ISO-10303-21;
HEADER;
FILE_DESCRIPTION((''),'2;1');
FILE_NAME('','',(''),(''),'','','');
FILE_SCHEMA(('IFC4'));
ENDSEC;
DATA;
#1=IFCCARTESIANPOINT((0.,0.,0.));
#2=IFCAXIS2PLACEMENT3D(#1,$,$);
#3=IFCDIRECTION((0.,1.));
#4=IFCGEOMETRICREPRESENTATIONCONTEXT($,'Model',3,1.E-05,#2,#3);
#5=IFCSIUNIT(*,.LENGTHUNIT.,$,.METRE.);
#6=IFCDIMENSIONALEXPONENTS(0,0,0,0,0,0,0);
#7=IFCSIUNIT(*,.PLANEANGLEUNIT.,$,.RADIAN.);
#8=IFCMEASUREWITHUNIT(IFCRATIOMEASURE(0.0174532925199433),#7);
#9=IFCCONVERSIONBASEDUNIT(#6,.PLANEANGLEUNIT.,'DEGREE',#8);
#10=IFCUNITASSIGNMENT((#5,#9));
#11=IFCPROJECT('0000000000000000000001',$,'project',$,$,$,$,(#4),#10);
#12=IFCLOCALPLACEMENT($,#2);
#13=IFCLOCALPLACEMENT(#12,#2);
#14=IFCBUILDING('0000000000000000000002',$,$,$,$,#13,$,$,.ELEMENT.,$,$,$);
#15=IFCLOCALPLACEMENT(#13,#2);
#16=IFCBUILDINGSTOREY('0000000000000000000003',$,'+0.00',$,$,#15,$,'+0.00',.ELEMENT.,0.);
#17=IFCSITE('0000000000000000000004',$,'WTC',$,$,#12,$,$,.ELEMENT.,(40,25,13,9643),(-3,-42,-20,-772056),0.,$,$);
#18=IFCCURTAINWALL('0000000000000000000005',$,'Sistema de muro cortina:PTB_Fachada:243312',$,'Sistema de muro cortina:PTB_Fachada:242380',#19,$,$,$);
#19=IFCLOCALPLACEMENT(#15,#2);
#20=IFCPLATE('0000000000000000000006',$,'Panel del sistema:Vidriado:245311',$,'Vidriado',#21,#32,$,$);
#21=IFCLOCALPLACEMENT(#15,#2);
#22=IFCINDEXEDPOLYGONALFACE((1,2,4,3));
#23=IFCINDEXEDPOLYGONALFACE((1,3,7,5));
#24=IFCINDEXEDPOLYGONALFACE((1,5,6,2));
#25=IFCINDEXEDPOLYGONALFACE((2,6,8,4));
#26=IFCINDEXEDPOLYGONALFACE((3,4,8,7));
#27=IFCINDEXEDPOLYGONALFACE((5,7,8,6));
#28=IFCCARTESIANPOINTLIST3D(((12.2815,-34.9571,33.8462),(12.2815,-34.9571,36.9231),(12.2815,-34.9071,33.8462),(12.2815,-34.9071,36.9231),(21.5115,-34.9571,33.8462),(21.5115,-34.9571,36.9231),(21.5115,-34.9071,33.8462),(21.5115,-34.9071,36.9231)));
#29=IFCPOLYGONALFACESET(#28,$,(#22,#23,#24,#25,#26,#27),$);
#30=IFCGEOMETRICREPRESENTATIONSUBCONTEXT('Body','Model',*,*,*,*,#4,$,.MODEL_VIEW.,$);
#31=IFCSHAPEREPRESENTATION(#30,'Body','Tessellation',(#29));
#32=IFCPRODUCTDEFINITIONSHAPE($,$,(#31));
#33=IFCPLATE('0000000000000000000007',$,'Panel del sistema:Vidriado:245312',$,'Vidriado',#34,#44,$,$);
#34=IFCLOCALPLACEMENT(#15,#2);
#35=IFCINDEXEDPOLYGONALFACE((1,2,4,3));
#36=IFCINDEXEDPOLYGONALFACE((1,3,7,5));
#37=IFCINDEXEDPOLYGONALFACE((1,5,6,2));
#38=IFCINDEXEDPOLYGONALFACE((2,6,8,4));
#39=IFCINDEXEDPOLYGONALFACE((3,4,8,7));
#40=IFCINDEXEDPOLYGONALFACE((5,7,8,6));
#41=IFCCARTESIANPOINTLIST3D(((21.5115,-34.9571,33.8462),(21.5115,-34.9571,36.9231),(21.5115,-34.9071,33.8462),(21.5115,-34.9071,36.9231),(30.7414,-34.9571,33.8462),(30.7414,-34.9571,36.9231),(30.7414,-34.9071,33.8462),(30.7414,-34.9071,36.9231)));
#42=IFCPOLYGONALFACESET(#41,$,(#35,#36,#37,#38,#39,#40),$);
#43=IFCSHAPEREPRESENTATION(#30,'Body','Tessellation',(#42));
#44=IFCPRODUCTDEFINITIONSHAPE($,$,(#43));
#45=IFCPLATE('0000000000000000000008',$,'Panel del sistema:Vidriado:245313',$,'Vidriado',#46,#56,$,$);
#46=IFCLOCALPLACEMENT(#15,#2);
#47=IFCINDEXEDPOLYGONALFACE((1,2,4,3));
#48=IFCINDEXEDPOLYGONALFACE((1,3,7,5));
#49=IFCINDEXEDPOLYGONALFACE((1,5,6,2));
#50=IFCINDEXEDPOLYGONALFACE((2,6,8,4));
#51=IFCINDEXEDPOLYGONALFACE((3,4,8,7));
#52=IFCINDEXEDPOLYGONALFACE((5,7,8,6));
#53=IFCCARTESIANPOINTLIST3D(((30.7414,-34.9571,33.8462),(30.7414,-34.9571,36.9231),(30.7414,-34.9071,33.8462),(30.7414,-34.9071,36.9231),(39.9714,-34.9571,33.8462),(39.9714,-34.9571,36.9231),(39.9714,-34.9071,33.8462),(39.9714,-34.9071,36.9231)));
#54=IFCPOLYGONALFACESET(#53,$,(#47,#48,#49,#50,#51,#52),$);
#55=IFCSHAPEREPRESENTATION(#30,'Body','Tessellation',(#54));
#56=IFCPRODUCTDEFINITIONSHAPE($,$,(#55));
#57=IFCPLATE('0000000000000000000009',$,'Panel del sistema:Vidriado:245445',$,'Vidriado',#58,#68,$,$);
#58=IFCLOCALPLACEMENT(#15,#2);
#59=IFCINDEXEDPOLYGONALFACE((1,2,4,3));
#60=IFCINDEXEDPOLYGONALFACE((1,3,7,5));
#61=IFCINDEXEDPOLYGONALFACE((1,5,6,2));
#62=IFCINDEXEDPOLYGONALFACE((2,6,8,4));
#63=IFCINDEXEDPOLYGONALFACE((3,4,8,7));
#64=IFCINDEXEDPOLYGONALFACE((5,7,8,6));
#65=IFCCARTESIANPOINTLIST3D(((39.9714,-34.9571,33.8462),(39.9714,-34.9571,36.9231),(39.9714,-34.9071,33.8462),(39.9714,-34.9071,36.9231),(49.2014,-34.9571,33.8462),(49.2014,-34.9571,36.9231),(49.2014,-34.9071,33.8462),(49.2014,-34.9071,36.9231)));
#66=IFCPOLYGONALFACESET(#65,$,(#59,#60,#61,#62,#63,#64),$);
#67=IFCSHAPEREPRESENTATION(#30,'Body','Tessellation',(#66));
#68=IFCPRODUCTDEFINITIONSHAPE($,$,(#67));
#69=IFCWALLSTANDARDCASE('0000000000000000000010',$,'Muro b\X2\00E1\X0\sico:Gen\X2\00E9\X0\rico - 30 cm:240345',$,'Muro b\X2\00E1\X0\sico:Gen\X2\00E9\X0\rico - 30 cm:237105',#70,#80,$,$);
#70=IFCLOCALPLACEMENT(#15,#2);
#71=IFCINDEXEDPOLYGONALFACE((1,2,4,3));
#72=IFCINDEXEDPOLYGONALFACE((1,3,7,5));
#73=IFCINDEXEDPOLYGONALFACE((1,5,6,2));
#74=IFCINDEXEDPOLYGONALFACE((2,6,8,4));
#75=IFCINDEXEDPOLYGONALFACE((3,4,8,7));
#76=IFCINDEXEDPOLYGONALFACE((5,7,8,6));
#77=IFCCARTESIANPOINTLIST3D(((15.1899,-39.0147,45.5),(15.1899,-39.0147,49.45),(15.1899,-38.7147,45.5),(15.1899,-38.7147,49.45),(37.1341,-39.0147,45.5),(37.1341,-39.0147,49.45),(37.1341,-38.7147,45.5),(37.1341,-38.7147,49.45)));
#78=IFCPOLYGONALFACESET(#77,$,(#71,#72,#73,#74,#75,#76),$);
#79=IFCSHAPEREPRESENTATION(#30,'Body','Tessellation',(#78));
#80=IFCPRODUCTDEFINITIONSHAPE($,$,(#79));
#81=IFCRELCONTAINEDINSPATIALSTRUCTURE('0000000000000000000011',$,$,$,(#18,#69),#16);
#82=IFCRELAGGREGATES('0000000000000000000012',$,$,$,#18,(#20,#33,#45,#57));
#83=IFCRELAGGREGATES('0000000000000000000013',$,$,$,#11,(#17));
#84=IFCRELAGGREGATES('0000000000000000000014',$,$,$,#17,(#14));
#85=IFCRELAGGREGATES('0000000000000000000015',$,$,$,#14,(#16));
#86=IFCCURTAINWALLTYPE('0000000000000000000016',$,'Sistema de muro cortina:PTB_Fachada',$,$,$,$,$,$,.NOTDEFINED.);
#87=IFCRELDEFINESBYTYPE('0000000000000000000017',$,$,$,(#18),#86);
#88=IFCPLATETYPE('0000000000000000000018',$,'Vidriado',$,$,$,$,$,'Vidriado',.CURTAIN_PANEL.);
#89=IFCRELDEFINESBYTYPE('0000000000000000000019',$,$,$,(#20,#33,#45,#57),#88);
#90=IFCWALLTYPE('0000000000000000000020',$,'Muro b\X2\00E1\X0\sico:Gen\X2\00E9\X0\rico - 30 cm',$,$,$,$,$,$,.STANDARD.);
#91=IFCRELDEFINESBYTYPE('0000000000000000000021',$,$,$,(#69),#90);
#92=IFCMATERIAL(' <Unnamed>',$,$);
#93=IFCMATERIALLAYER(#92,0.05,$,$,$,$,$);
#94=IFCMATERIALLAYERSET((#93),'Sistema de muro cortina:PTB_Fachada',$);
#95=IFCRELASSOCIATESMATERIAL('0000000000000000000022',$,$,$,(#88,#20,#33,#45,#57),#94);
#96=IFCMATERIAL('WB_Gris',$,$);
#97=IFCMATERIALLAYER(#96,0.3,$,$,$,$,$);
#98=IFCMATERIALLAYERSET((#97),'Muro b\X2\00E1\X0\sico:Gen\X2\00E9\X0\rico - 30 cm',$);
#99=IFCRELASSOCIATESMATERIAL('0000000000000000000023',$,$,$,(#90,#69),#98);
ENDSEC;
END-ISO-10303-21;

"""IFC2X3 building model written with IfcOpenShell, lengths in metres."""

from ifc_helpers import new_model, entity, si_unit, converted_unit, direction, frame, frame_2d, origin, origin_2d_with_axis, place, context, subcontext, project, spatial, polyline, rectangle, extrude, clip, bounded_halfspace, source, transform, mapped, material, layer, layer_set, layer_usage, type_object, type_shapes, element, aggregate, save


model = new_model("IFC2X3")

# Units and contexts
model_context = context("Model", 3, precision=1e-05, world=origin(), true_north=direction((0.0, 1.0)))
body_context = subcontext(model_context, "Body", "Model", "MODEL_VIEW")
ifc_project = project(units=[si_unit("LENGTHUNIT", "METRE"), converted_unit("PLANEANGLEUNIT", "DEGREE", entity("IfcRatioMeasure", 0.0174532925199433), si_unit("PLANEANGLEUNIT", "RADIAN"), dimensions=[0, 0, 0, 0, 0, 0, 0])], contexts=[model_context])

# Site, building, storey
site_placement = place(None, origin())
site = spatial("IfcSite", under=ifc_project, at=site_placement, Name="WTC", CompositionType="ELEMENT", RefLatitude=(40, 25, 13, 9643), RefLongitude=(-3, -42, -20, -772056), RefElevation=0.0)
building_placement = place(site_placement, origin())
building = spatial("IfcBuilding", under=site, at=building_placement, CompositionType="ELEMENT")
storey_placement = place(building_placement, origin())
storey = spatial("IfcBuildingStorey", under=building, at=storey_placement, Name="+0.00", LongName="+0.00", CompositionType="ELEMENT", Elevation=0.0)

# Curtain wall, plates
curtain_wall_type = type_object("IfcCurtainWallType", Name="Sistema de muro cortina:PTB_Fachada", PredefinedType="NOTDEFINED")
curtain_wall_placement = place(storey_placement, origin())
curtain_wall = element("IfcCurtainWall", 1, at=curtain_wall_placement, inside=storey, type_object=curtain_wall_type, Name="Sistema de muro cortina:PTB_Fachada:243312", ObjectType="Sistema de muro cortina:PTB_Fachada:242380")
ifc_material_1 = material(Name=" <Unnamed>")
ifc_layer_1 = layer(ifc_material_1, 0.05)
ifc_layer_set_1 = layer_set([ifc_layer_1], Name="Sistema de muro cortina:PTB_Fachada")
plate_type_1 = type_object("IfcPlateType", Name="Vidriado", ElementType="Vidriado", PredefinedType="CURTAIN_PANEL", material=ifc_layer_set_1)
shared_shape_1 = source(origin(), body_context, "Body", "SweptSolid", [
    extrude(rectangle(XDim=0.05, YDim=9.23, at=origin_2d_with_axis()), frame((0.0, 0.0, 0.0), z_axis=(0.0, 0.0, 1.0), x_axis=(0.0, 1.0, 0.0)), (0.0, 0.0, 1.0), 3.0769),
])
type_shapes(plate_type_1, [shared_shape_1])
ifc_layer_usage_1 = layer_usage(ifc_layer_set_1, "AXIS3", "POSITIVE", 0.0)
plate_1_placement = place(curtain_wall_placement, frame((16.8965, -34.9321, 33.8462)))
plate_1 = element("IfcPlate", 2, at=plate_1_placement, type_object=plate_type_1, material=ifc_layer_usage_1, Name="Panel del sistema:Vidriado:245311", ObjectType="Vidriado", context=body_context, shape_type="MappedRepresentation", body=[
    mapped(shared_shape_1, transform((0.0, 0.0, 0.0), scale=1.0)),
])
ifc_layer_usage_2 = layer_usage(ifc_layer_set_1, "AXIS3", "POSITIVE", 0.0)
plate_2_placement = place(curtain_wall_placement, frame((26.1265, -34.9321, 33.8462)))
plate_2 = element("IfcPlate", 3, at=plate_2_placement, type_object=plate_type_1, material=ifc_layer_usage_2, Name="Panel del sistema:Vidriado:245312", ObjectType="Vidriado", context=body_context, shape_type="MappedRepresentation", body=[
    mapped(shared_shape_1, transform((0.0, 0.0, 0.0), scale=1.0)),
])
ifc_layer_usage_3 = layer_usage(ifc_layer_set_1, "AXIS3", "POSITIVE", 0.0)
plate_3_placement = place(curtain_wall_placement, frame((35.3564, -34.9321, 33.8462)))
plate_3 = element("IfcPlate", 4, at=plate_3_placement, type_object=plate_type_1, material=ifc_layer_usage_3, Name="Panel del sistema:Vidriado:245313", ObjectType="Vidriado", context=body_context, shape_type="MappedRepresentation", body=[
    mapped(shared_shape_1, transform((0.0, 0.0, 0.0), scale=1.0)),
])
ifc_layer_usage_4 = layer_usage(ifc_layer_set_1, "AXIS3", "POSITIVE", 0.0)
plate_4_placement = place(curtain_wall_placement, frame((44.5864, -34.9321, 33.8462)))
plate_4 = element("IfcPlate", 5, at=plate_4_placement, type_object=plate_type_1, material=ifc_layer_usage_4, Name="Panel del sistema:Vidriado:245445", ObjectType="Vidriado", context=body_context, shape_type="MappedRepresentation", body=[
    mapped(shared_shape_1, transform((0.0, 0.0, 0.0), scale=1.0)),
])
aggregate(curtain_wall, [plate_1, plate_2, plate_3, plate_4])

# Wall
ifc_material_2 = material(Name="WB_Gris")
ifc_layer_2 = layer(ifc_material_2, 0.3)
ifc_layer_set_2 = layer_set([ifc_layer_2], Name="Muro básico:Genérico - 30 cm")
wall_type = type_object("IfcWallType", Name="Muro básico:Genérico - 30 cm", PredefinedType="STANDARD", material=ifc_layer_set_2)
ifc_layer_usage_5 = layer_usage(ifc_layer_set_2, "AXIS2", "POSITIVE", -0.15)
wall_1_placement = place(storey_placement, frame((37.1341, -38.8647, 45.5), z_axis=(0.0, 0.0, 1.0), x_axis=(-1.0, 0.0, 0.0)))
element("IfcWallStandardCase", 6, at=wall_1_placement, inside=storey, type_object=wall_type, material=ifc_layer_usage_5, Name="Muro básico:Genérico - 30 cm:240345", ObjectType="Muro básico:Genérico - 30 cm:237105", context=body_context, shape_type="Clipping", body=[
    clip(extrude(rectangle(XDim=21.9441, YDim=0.3, at=frame_2d((10.9721, 0.0), x_axis=(-1.0, 0.0))), origin(), (0.0, 0.0, 1.0), 3.95), bounded_halfspace(frame((0.0, -0.15, 3.95)), False, frame((0.0, -0.15, 3.95)), polyline([(0.0, 0.0), (21.9441, 0.0), (21.9441, 0.3), (0.0, 0.3), (0.0, 0.0)]))),
])

save(model, "model.ifc")
